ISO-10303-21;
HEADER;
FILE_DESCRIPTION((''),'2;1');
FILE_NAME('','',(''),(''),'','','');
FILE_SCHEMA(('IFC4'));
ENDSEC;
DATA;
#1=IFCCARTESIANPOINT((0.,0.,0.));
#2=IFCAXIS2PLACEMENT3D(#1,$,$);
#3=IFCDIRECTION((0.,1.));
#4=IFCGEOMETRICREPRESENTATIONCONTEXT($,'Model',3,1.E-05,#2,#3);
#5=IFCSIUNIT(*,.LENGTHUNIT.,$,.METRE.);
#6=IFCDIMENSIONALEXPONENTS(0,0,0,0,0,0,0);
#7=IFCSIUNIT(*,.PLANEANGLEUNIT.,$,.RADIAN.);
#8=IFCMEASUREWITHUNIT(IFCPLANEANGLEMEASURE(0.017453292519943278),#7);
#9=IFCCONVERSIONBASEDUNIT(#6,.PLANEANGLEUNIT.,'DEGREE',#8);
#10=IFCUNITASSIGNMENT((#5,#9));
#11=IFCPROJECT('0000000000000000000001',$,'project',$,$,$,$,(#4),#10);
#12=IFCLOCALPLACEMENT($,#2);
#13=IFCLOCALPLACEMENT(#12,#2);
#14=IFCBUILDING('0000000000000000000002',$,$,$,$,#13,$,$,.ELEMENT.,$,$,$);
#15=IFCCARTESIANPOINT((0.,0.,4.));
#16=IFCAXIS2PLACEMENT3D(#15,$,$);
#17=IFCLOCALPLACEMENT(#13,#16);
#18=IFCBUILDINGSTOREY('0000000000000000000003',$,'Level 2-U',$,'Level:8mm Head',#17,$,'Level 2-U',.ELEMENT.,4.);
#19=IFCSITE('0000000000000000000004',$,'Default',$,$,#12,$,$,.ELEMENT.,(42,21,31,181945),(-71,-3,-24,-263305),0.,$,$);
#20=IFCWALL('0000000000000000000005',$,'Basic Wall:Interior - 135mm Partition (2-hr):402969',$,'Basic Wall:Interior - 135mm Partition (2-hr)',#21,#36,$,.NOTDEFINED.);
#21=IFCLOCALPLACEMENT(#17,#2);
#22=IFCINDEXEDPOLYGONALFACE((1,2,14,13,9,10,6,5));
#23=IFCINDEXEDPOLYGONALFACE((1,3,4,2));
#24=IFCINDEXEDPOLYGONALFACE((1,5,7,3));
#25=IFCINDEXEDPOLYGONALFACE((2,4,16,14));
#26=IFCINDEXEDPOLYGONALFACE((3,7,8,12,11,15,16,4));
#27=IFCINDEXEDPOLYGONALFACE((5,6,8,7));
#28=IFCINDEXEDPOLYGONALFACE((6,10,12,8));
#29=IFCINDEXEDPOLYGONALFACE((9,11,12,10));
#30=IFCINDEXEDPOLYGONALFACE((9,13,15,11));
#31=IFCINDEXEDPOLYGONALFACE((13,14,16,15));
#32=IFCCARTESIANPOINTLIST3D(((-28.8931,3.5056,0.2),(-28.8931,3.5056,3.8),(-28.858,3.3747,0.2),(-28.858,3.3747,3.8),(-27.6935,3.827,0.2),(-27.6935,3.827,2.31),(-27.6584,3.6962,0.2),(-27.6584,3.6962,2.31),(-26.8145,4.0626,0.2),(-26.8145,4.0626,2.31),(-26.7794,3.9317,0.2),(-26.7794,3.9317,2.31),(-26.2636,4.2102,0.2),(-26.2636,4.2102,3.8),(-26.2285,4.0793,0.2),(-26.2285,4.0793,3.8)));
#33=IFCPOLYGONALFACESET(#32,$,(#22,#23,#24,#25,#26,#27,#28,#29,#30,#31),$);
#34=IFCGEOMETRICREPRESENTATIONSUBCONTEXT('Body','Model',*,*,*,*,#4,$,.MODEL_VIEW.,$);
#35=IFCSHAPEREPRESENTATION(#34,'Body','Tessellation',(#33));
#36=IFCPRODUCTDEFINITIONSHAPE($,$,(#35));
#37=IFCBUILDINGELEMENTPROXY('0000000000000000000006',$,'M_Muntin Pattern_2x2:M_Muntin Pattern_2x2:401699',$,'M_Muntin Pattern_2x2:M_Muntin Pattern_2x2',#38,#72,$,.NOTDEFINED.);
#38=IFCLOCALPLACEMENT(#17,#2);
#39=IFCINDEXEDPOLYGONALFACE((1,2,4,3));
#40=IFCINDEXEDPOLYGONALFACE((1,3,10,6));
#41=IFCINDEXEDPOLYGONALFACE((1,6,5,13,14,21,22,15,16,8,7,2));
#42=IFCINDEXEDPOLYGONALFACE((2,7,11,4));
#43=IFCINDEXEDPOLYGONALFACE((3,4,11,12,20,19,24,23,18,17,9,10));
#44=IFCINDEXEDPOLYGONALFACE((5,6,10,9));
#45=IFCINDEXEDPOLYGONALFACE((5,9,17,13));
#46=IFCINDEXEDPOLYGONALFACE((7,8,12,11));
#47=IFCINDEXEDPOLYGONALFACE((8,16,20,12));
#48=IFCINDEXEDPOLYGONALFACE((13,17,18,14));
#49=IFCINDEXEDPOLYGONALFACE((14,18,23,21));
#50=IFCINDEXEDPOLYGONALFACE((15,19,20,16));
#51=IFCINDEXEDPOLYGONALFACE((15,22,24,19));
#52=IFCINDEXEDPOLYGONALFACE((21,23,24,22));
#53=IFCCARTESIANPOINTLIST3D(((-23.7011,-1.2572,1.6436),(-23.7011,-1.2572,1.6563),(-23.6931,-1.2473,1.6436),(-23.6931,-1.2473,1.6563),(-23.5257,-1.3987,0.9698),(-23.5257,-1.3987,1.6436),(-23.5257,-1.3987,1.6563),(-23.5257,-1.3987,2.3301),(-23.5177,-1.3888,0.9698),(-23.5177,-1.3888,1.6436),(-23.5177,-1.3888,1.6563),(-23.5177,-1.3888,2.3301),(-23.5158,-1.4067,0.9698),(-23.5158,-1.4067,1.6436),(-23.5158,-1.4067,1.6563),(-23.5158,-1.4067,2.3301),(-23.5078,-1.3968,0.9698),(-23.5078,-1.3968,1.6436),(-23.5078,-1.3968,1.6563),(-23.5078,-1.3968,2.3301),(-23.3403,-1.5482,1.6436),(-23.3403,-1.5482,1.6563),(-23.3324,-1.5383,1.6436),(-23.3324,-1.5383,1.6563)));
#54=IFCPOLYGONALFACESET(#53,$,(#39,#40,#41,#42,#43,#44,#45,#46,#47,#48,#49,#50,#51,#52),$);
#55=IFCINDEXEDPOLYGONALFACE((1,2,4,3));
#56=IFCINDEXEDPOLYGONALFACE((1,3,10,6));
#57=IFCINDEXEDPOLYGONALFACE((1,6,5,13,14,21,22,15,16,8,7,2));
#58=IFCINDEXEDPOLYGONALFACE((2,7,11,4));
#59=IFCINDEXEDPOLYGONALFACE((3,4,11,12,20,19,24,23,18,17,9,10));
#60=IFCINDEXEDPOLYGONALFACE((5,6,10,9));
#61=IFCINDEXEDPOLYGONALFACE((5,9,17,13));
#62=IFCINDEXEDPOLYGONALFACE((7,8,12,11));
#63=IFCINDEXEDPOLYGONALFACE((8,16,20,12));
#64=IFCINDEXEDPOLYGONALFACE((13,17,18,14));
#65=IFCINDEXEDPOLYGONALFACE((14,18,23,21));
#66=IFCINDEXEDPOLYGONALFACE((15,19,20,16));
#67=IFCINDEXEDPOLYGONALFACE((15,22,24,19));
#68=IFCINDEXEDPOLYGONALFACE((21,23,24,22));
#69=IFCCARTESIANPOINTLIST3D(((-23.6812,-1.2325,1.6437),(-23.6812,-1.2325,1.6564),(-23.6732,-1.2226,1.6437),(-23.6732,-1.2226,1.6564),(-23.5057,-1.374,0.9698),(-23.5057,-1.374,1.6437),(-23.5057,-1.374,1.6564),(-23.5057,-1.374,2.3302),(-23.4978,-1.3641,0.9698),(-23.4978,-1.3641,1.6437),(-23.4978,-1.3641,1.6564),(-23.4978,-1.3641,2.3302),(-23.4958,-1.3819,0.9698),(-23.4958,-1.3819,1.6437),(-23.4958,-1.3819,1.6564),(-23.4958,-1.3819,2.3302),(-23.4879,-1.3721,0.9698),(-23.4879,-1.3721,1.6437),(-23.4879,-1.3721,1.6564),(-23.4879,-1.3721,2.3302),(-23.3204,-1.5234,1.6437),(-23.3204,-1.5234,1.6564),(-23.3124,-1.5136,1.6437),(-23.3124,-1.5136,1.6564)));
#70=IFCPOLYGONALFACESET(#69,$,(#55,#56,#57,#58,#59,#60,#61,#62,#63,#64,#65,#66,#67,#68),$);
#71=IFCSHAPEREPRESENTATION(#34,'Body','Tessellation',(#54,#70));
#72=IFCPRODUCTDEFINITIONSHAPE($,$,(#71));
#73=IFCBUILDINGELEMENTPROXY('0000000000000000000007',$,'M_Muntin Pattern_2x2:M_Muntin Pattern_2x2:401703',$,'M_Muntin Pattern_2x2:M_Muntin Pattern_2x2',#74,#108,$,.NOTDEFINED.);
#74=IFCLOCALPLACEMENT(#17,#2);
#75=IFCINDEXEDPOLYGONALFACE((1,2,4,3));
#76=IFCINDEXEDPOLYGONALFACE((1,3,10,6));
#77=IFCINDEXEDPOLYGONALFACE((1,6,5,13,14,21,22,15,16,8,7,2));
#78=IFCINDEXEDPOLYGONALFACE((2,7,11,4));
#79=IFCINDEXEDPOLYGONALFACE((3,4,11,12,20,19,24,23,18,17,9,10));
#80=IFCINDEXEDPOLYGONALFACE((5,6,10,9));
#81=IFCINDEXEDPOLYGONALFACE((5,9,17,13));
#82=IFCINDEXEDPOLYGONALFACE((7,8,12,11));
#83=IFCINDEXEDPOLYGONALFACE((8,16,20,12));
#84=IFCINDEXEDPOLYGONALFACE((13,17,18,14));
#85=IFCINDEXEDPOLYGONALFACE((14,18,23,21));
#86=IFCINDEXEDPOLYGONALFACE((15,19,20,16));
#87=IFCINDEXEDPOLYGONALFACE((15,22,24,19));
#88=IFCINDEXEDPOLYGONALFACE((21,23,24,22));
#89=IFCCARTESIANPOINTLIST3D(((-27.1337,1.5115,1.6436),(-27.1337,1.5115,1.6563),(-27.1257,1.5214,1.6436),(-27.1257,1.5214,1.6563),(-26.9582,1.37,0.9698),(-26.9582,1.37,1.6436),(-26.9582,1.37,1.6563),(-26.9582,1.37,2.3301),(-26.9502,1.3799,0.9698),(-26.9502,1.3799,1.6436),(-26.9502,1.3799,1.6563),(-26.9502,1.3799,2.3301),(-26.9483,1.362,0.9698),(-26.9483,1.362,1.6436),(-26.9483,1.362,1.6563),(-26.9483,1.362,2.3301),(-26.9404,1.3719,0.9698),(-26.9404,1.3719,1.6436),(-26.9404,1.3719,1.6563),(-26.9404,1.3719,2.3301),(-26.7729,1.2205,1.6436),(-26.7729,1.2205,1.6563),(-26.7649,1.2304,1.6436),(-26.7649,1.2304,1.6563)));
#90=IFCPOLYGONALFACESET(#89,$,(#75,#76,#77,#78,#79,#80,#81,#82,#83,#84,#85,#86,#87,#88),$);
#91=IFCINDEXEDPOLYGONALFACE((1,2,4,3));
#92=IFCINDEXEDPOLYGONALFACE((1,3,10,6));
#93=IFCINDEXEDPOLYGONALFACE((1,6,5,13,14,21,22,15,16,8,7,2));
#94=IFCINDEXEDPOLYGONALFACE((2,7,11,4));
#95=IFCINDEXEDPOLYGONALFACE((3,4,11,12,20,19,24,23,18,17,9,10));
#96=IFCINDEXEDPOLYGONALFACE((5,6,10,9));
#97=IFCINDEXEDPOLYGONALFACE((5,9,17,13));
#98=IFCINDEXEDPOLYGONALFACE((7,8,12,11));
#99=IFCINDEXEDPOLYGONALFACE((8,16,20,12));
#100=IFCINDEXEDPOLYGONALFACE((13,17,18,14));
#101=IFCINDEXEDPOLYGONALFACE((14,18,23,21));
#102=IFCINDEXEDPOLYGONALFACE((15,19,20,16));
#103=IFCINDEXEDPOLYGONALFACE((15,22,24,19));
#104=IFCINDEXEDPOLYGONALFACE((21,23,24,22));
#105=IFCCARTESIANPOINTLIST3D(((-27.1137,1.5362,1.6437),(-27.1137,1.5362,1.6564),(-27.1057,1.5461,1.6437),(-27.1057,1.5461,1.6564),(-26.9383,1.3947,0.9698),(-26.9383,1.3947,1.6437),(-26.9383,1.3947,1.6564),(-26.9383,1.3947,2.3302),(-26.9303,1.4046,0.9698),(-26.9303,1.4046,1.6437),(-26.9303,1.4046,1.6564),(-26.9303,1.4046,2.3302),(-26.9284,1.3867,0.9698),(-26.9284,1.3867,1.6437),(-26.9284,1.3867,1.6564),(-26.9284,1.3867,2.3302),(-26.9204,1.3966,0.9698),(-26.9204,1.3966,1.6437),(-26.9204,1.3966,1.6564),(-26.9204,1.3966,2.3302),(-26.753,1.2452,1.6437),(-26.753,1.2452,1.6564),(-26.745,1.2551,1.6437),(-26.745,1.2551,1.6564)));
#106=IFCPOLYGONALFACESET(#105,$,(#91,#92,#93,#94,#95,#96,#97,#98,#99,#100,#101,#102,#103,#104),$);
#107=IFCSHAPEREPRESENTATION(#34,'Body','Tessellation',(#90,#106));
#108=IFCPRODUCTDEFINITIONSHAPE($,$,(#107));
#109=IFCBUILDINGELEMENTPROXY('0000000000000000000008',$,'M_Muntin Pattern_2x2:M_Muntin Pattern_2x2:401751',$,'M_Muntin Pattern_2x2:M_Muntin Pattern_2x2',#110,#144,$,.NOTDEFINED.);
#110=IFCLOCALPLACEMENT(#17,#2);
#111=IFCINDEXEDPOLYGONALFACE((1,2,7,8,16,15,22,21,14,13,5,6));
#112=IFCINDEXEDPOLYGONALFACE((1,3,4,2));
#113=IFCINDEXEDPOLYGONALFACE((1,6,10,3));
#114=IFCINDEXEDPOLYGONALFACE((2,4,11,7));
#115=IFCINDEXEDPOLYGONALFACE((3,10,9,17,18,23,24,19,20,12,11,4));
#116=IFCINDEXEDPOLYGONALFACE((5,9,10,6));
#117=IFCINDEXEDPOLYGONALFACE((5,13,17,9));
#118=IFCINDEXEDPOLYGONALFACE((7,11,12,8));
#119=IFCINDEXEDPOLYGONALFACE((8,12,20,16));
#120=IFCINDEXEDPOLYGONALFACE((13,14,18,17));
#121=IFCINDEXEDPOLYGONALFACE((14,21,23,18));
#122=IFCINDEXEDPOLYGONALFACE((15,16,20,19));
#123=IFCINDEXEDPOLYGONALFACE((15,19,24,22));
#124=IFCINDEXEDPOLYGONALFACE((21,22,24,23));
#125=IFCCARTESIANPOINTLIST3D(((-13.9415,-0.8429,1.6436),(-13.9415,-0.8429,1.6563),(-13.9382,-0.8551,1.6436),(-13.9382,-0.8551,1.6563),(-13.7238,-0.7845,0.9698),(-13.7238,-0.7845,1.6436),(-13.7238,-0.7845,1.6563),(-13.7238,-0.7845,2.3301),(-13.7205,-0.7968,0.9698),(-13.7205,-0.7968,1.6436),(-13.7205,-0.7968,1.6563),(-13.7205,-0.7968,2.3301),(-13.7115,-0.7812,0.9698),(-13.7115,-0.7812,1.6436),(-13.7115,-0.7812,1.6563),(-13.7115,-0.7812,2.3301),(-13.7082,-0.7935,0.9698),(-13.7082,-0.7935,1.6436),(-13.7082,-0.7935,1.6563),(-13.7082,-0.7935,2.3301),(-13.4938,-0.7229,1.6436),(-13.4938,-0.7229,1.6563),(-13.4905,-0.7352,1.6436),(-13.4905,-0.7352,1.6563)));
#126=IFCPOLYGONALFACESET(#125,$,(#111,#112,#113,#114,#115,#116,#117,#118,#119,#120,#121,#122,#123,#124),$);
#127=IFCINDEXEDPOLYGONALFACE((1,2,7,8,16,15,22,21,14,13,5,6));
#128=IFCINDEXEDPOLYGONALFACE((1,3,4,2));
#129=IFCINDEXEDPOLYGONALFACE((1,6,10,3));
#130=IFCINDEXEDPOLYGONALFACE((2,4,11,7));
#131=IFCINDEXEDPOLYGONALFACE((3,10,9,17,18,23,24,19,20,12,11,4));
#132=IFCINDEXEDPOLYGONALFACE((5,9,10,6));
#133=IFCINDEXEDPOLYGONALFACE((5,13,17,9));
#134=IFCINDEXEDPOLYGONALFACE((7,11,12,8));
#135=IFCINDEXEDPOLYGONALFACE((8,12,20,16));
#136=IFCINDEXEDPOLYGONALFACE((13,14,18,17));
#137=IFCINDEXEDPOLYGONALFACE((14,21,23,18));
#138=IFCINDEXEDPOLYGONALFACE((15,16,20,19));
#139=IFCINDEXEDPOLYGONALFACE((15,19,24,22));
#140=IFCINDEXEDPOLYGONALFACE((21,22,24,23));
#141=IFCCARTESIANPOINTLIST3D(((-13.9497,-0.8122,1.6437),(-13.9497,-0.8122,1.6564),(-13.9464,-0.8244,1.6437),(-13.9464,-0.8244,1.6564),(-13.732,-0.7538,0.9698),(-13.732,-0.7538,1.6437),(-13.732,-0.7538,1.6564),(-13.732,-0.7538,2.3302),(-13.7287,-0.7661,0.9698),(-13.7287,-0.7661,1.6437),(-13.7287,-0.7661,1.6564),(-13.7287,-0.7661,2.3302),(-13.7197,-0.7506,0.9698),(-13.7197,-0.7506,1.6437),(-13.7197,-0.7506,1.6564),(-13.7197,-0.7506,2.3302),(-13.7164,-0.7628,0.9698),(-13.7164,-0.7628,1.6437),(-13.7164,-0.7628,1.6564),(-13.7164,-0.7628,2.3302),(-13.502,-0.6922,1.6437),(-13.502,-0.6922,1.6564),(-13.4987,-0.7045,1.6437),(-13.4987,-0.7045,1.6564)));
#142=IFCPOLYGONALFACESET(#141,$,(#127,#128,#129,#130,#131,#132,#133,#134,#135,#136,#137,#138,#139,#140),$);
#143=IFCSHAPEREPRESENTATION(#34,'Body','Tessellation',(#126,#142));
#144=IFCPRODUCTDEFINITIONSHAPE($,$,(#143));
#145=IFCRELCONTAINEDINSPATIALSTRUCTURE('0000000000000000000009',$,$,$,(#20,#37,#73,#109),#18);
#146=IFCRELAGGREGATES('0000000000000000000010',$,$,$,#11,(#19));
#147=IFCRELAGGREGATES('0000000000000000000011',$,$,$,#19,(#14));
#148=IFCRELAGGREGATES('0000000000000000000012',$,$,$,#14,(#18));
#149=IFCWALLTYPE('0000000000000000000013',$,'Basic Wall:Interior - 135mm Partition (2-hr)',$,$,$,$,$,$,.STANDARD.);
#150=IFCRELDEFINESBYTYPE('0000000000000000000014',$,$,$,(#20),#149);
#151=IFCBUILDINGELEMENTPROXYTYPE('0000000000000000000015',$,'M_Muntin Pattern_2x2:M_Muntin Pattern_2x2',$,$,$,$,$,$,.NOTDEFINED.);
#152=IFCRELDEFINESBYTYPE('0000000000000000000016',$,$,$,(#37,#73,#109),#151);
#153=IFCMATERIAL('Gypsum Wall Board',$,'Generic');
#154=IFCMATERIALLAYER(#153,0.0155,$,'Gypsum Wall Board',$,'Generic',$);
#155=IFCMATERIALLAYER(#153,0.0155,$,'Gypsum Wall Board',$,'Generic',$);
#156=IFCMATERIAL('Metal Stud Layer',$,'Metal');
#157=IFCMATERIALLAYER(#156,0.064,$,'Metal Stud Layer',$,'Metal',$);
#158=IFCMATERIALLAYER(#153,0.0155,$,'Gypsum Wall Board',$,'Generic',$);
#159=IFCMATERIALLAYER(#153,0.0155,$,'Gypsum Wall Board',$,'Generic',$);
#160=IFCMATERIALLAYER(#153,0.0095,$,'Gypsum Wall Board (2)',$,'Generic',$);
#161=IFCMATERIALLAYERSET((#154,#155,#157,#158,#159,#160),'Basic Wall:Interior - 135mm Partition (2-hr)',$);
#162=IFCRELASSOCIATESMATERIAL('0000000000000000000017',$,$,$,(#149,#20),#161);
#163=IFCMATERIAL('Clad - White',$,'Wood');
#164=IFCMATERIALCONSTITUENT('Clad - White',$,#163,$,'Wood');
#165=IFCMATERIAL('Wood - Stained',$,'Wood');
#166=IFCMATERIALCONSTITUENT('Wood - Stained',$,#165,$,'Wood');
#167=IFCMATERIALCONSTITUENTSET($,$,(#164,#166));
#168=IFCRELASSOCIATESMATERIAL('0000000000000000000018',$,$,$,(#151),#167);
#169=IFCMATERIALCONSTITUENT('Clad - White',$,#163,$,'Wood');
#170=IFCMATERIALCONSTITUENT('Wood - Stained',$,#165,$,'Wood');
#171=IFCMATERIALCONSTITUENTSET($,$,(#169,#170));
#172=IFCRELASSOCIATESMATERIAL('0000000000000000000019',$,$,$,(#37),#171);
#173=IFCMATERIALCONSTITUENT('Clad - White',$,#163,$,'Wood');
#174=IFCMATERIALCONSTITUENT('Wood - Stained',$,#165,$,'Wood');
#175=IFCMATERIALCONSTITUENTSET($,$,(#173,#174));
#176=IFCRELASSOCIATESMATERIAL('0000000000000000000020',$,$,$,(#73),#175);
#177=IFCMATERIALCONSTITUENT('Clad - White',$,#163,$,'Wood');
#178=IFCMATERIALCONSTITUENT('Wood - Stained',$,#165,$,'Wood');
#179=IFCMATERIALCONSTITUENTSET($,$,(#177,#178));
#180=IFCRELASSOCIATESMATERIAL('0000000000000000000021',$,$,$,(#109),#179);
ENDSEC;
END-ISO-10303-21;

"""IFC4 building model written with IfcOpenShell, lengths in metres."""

from ifc_helpers import new_model, entity, si_unit, converted_unit, direction, frame, frame_2d, origin, place, context, subcontext, project, spatial, polyline, rectangle, outline, extrude, source, transform, mapped, material, layer, layer_set, layer_usage, constituent, constituent_set, type_object, type_shapes, element, save


model = new_model("IFC4")

# Units and contexts
model_context = context("Model", 3, precision=1e-05, world=origin(), true_north=direction((0.0, 1.0)))
body_context = subcontext(model_context, "Body", "Model", "MODEL_VIEW")
ifc_project = project(units=[si_unit("LENGTHUNIT", "METRE"), converted_unit("PLANEANGLEUNIT", "DEGREE", entity("IfcPlaneAngleMeasure", 0.017453292519943278), si_unit("PLANEANGLEUNIT", "RADIAN"), dimensions=[0, 0, 0, 0, 0, 0, 0])], contexts=[model_context])

# Site, building, storey
site_placement = place(None, origin())
site = spatial("IfcSite", under=ifc_project, at=site_placement, Name="Default", CompositionType="ELEMENT", RefLatitude=(42, 21, 31, 181945), RefLongitude=(-71, -3, -24, -263305), RefElevation=0.0)
building_placement = place(site_placement, origin())
building = spatial("IfcBuilding", under=site, at=building_placement, CompositionType="ELEMENT")
storey_placement = place(building_placement, frame((0.0, 0.0, 4.0)))
storey = spatial("IfcBuildingStorey", under=building, at=storey_placement, Name="Level 2-U", ObjectType="Level:8mm Head", LongName="Level 2-U", CompositionType="ELEMENT", Elevation=4.0)

# Shared definitions
ifc_material_1 = material(Name="Gypsum Wall Board", Category="Generic")
ifc_layer_1 = layer(ifc_material_1, 0.0155, Name="Gypsum Wall Board", Category="Generic")
ifc_layer_2 = layer(ifc_material_1, 0.0155, Name="Gypsum Wall Board", Category="Generic")
ifc_material_2 = material(Name="Metal Stud Layer", Category="Metal")
ifc_layer_3 = layer(ifc_material_2, 0.064, Name="Metal Stud Layer", Category="Metal")
ifc_layer_4 = layer(ifc_material_1, 0.0155, Name="Gypsum Wall Board", Category="Generic")
ifc_layer_5 = layer(ifc_material_1, 0.0155, Name="Gypsum Wall Board", Category="Generic")
ifc_layer_6 = layer(ifc_material_1, 0.0095, Name="Gypsum Wall Board (2)", Category="Generic")
ifc_layer_set_1 = layer_set([ifc_layer_1, ifc_layer_2, ifc_layer_3, ifc_layer_4, ifc_layer_5, ifc_layer_6], Name="Basic Wall:Interior - 135mm Partition (2-hr)")
ifc_layer_usage_1 = layer_usage(ifc_layer_set_1, "AXIS2", "NEGATIVE", 0.0677)
wall_type_1 = type_object("IfcWallType", Name="Basic Wall:Interior - 135mm Partition (2-hr)", PredefinedType="STANDARD", material=ifc_layer_set_1)

# Wall, opening
wall_1_placement = place(storey_placement, frame((-26.246, 4.1447, 0.2), z_axis=(0.0, 0.0, 1.0), x_axis=(-0.965926, -0.258819, 0.0)))
wall_1 = element("IfcWall", 1, at=wall_1_placement, inside=storey, type_object=wall_type_1, material=ifc_layer_usage_1, Name="Basic Wall:Interior - 135mm Partition (2-hr):402969", ObjectType="Basic Wall:Interior - 135mm Partition (2-hr)", PredefinedType="NOTDEFINED", context=body_context, shape_type="SweptSolid", body=[
    extrude(rectangle(XDim=2.7222, YDim=0.1355, at=frame_2d((1.3611, 0.0), x_axis=(-1.0, 0.0))), origin(), (0.0, 0.0, 1.0), 3.6),
])
opening_1_placement = place(wall_1_placement, frame((0.5704, -0.0678, 0.0)))
element("IfcOpeningElement", 2, at=opening_1_placement, cuts=wall_1, PredefinedType="OPENING", context=body_context, shape_type="SweptSolid", body=[
    extrude(rectangle(XDim=2.11, YDim=0.91, at=frame_2d((1.055, 0.455), x_axis=(1.0, 0.0))), frame((0.0, 0.0, 0.0), z_axis=(0.0, 1.0, 0.0), x_axis=(0.0, 0.0, 1.0)), (0.0, 0.0, 1.0), 0.1355),
])

# Building element proxies
ifc_material_3 = material(Name="Clad - White", Category="Wood")
ifc_constituent_1 = constituent(ifc_material_3, Name="Clad - White", Category="Wood")
ifc_material_4 = material(Name="Wood - Stained", Category="Wood")
ifc_constituent_2 = constituent(ifc_material_4, Name="Wood - Stained", Category="Wood")
ifc_constituent_set_1 = constituent_set(constituents=[ifc_constituent_1, ifc_constituent_2])
ifc_constituent_3 = constituent(ifc_material_3, Name="Clad - White", Category="Wood")
ifc_constituent_4 = constituent(ifc_material_4, Name="Wood - Stained", Category="Wood")
ifc_constituent_set_2 = constituent_set(constituents=[ifc_constituent_3, ifc_constituent_4])
building_element_proxy_type_1 = type_object("IfcBuildingElementProxyType", Name="M_Muntin Pattern_2x2:M_Muntin Pattern_2x2", PredefinedType="NOTDEFINED", material=ifc_constituent_set_2)
shared_shape_1 = source(origin(), body_context, "Body", "SweptSolid", [
    extrude(outline(polyline([(0.0064, -0.0064), (0.6801, -0.0064), (0.6801, 0.0063), (0.0064, 0.0063), (0.0064, 0.2317), (-0.0063, 0.2317), (-0.0063, 0.0063), (-0.6802, 0.0063), (-0.6802, -0.0064), (-0.0063, -0.0064), (-0.0063, -0.2317), (0.0064, -0.2317), (0.0064, -0.0064)])), frame((0.0, 0.0095, 0.6801), z_axis=(0.0, 1.0, 0.0), x_axis=(0.0, 0.0, 1.0)), (0.0, 0.0, 1.0), 0.0127),
    extrude(outline(polyline([(0.0064, -0.0064), (0.6802, -0.0064), (0.6802, 0.0063), (0.0064, 0.0063), (0.0064, 0.2317), (-0.0063, 0.2317), (-0.0063, 0.0063), (-0.6802, 0.0063), (-0.6802, -0.0064), (-0.0063, -0.0064), (-0.0063, -0.2317), (0.0064, -0.2317), (0.0064, -0.0064)])), frame((0.0, -0.0222, 0.6802), z_axis=(0.0, 1.0, 0.0), x_axis=(0.0, 0.0, 1.0)), (0.0, 0.0, 1.0), 0.0127),
])
type_shapes(building_element_proxy_type_1, [shared_shape_1])
proxy_1_placement = place(storey_placement, frame((-23.5068, -1.3854, 0.9698), z_axis=(0.0, 0.0, 1.0), x_axis=(-0.778359, 0.62782, 0.0)))
element("IfcBuildingElementProxy", 3, at=proxy_1_placement, inside=storey, type_object=building_element_proxy_type_1, material=ifc_constituent_set_1, Name="M_Muntin Pattern_2x2:M_Muntin Pattern_2x2:401699", ObjectType="M_Muntin Pattern_2x2:M_Muntin Pattern_2x2", PredefinedType="NOTDEFINED", context=body_context, shape_type="MappedRepresentation", body=[
    mapped(shared_shape_1, transform((0.0, 0.0, 0.0), scale=1.0)),
])
ifc_constituent_5 = constituent(ifc_material_3, Name="Clad - White", Category="Wood")
ifc_constituent_6 = constituent(ifc_material_4, Name="Wood - Stained", Category="Wood")
ifc_constituent_set_3 = constituent_set(constituents=[ifc_constituent_5, ifc_constituent_6])
proxy_2_placement = place(storey_placement, frame((-26.9393, 1.3833, 0.9698), z_axis=(0.0, 0.0, 1.0), x_axis=(-0.778359, 0.62782, 0.0)))
element("IfcBuildingElementProxy", 4, at=proxy_2_placement, inside=storey, type_object=building_element_proxy_type_1, material=ifc_constituent_set_3, Name="M_Muntin Pattern_2x2:M_Muntin Pattern_2x2:401703", ObjectType="M_Muntin Pattern_2x2:M_Muntin Pattern_2x2", PredefinedType="NOTDEFINED", context=body_context, shape_type="MappedRepresentation", body=[
    mapped(shared_shape_1, transform((0.0, 0.0, 0.0), scale=1.0)),
])
ifc_constituent_7 = constituent(ifc_material_3, Name="Clad - White", Category="Wood")
ifc_constituent_8 = constituent(ifc_material_4, Name="Wood - Stained", Category="Wood")
ifc_constituent_set_4 = constituent_set(constituents=[ifc_constituent_7, ifc_constituent_8])
proxy_3_placement = place(storey_placement, frame((-13.7201, -0.7737, 0.9698), z_axis=(0.0, 0.0, 1.0), x_axis=(-0.965926, -0.258819, 0.0)))
element("IfcBuildingElementProxy", 5, at=proxy_3_placement, inside=storey, type_object=building_element_proxy_type_1, material=ifc_constituent_set_4, Name="M_Muntin Pattern_2x2:M_Muntin Pattern_2x2:401751", ObjectType="M_Muntin Pattern_2x2:M_Muntin Pattern_2x2", PredefinedType="NOTDEFINED", context=body_context, shape_type="MappedRepresentation", body=[
    mapped(shared_shape_1, transform((0.0, 0.0, 0.0), scale=1.0)),
])

save(model, "model.ifc")
